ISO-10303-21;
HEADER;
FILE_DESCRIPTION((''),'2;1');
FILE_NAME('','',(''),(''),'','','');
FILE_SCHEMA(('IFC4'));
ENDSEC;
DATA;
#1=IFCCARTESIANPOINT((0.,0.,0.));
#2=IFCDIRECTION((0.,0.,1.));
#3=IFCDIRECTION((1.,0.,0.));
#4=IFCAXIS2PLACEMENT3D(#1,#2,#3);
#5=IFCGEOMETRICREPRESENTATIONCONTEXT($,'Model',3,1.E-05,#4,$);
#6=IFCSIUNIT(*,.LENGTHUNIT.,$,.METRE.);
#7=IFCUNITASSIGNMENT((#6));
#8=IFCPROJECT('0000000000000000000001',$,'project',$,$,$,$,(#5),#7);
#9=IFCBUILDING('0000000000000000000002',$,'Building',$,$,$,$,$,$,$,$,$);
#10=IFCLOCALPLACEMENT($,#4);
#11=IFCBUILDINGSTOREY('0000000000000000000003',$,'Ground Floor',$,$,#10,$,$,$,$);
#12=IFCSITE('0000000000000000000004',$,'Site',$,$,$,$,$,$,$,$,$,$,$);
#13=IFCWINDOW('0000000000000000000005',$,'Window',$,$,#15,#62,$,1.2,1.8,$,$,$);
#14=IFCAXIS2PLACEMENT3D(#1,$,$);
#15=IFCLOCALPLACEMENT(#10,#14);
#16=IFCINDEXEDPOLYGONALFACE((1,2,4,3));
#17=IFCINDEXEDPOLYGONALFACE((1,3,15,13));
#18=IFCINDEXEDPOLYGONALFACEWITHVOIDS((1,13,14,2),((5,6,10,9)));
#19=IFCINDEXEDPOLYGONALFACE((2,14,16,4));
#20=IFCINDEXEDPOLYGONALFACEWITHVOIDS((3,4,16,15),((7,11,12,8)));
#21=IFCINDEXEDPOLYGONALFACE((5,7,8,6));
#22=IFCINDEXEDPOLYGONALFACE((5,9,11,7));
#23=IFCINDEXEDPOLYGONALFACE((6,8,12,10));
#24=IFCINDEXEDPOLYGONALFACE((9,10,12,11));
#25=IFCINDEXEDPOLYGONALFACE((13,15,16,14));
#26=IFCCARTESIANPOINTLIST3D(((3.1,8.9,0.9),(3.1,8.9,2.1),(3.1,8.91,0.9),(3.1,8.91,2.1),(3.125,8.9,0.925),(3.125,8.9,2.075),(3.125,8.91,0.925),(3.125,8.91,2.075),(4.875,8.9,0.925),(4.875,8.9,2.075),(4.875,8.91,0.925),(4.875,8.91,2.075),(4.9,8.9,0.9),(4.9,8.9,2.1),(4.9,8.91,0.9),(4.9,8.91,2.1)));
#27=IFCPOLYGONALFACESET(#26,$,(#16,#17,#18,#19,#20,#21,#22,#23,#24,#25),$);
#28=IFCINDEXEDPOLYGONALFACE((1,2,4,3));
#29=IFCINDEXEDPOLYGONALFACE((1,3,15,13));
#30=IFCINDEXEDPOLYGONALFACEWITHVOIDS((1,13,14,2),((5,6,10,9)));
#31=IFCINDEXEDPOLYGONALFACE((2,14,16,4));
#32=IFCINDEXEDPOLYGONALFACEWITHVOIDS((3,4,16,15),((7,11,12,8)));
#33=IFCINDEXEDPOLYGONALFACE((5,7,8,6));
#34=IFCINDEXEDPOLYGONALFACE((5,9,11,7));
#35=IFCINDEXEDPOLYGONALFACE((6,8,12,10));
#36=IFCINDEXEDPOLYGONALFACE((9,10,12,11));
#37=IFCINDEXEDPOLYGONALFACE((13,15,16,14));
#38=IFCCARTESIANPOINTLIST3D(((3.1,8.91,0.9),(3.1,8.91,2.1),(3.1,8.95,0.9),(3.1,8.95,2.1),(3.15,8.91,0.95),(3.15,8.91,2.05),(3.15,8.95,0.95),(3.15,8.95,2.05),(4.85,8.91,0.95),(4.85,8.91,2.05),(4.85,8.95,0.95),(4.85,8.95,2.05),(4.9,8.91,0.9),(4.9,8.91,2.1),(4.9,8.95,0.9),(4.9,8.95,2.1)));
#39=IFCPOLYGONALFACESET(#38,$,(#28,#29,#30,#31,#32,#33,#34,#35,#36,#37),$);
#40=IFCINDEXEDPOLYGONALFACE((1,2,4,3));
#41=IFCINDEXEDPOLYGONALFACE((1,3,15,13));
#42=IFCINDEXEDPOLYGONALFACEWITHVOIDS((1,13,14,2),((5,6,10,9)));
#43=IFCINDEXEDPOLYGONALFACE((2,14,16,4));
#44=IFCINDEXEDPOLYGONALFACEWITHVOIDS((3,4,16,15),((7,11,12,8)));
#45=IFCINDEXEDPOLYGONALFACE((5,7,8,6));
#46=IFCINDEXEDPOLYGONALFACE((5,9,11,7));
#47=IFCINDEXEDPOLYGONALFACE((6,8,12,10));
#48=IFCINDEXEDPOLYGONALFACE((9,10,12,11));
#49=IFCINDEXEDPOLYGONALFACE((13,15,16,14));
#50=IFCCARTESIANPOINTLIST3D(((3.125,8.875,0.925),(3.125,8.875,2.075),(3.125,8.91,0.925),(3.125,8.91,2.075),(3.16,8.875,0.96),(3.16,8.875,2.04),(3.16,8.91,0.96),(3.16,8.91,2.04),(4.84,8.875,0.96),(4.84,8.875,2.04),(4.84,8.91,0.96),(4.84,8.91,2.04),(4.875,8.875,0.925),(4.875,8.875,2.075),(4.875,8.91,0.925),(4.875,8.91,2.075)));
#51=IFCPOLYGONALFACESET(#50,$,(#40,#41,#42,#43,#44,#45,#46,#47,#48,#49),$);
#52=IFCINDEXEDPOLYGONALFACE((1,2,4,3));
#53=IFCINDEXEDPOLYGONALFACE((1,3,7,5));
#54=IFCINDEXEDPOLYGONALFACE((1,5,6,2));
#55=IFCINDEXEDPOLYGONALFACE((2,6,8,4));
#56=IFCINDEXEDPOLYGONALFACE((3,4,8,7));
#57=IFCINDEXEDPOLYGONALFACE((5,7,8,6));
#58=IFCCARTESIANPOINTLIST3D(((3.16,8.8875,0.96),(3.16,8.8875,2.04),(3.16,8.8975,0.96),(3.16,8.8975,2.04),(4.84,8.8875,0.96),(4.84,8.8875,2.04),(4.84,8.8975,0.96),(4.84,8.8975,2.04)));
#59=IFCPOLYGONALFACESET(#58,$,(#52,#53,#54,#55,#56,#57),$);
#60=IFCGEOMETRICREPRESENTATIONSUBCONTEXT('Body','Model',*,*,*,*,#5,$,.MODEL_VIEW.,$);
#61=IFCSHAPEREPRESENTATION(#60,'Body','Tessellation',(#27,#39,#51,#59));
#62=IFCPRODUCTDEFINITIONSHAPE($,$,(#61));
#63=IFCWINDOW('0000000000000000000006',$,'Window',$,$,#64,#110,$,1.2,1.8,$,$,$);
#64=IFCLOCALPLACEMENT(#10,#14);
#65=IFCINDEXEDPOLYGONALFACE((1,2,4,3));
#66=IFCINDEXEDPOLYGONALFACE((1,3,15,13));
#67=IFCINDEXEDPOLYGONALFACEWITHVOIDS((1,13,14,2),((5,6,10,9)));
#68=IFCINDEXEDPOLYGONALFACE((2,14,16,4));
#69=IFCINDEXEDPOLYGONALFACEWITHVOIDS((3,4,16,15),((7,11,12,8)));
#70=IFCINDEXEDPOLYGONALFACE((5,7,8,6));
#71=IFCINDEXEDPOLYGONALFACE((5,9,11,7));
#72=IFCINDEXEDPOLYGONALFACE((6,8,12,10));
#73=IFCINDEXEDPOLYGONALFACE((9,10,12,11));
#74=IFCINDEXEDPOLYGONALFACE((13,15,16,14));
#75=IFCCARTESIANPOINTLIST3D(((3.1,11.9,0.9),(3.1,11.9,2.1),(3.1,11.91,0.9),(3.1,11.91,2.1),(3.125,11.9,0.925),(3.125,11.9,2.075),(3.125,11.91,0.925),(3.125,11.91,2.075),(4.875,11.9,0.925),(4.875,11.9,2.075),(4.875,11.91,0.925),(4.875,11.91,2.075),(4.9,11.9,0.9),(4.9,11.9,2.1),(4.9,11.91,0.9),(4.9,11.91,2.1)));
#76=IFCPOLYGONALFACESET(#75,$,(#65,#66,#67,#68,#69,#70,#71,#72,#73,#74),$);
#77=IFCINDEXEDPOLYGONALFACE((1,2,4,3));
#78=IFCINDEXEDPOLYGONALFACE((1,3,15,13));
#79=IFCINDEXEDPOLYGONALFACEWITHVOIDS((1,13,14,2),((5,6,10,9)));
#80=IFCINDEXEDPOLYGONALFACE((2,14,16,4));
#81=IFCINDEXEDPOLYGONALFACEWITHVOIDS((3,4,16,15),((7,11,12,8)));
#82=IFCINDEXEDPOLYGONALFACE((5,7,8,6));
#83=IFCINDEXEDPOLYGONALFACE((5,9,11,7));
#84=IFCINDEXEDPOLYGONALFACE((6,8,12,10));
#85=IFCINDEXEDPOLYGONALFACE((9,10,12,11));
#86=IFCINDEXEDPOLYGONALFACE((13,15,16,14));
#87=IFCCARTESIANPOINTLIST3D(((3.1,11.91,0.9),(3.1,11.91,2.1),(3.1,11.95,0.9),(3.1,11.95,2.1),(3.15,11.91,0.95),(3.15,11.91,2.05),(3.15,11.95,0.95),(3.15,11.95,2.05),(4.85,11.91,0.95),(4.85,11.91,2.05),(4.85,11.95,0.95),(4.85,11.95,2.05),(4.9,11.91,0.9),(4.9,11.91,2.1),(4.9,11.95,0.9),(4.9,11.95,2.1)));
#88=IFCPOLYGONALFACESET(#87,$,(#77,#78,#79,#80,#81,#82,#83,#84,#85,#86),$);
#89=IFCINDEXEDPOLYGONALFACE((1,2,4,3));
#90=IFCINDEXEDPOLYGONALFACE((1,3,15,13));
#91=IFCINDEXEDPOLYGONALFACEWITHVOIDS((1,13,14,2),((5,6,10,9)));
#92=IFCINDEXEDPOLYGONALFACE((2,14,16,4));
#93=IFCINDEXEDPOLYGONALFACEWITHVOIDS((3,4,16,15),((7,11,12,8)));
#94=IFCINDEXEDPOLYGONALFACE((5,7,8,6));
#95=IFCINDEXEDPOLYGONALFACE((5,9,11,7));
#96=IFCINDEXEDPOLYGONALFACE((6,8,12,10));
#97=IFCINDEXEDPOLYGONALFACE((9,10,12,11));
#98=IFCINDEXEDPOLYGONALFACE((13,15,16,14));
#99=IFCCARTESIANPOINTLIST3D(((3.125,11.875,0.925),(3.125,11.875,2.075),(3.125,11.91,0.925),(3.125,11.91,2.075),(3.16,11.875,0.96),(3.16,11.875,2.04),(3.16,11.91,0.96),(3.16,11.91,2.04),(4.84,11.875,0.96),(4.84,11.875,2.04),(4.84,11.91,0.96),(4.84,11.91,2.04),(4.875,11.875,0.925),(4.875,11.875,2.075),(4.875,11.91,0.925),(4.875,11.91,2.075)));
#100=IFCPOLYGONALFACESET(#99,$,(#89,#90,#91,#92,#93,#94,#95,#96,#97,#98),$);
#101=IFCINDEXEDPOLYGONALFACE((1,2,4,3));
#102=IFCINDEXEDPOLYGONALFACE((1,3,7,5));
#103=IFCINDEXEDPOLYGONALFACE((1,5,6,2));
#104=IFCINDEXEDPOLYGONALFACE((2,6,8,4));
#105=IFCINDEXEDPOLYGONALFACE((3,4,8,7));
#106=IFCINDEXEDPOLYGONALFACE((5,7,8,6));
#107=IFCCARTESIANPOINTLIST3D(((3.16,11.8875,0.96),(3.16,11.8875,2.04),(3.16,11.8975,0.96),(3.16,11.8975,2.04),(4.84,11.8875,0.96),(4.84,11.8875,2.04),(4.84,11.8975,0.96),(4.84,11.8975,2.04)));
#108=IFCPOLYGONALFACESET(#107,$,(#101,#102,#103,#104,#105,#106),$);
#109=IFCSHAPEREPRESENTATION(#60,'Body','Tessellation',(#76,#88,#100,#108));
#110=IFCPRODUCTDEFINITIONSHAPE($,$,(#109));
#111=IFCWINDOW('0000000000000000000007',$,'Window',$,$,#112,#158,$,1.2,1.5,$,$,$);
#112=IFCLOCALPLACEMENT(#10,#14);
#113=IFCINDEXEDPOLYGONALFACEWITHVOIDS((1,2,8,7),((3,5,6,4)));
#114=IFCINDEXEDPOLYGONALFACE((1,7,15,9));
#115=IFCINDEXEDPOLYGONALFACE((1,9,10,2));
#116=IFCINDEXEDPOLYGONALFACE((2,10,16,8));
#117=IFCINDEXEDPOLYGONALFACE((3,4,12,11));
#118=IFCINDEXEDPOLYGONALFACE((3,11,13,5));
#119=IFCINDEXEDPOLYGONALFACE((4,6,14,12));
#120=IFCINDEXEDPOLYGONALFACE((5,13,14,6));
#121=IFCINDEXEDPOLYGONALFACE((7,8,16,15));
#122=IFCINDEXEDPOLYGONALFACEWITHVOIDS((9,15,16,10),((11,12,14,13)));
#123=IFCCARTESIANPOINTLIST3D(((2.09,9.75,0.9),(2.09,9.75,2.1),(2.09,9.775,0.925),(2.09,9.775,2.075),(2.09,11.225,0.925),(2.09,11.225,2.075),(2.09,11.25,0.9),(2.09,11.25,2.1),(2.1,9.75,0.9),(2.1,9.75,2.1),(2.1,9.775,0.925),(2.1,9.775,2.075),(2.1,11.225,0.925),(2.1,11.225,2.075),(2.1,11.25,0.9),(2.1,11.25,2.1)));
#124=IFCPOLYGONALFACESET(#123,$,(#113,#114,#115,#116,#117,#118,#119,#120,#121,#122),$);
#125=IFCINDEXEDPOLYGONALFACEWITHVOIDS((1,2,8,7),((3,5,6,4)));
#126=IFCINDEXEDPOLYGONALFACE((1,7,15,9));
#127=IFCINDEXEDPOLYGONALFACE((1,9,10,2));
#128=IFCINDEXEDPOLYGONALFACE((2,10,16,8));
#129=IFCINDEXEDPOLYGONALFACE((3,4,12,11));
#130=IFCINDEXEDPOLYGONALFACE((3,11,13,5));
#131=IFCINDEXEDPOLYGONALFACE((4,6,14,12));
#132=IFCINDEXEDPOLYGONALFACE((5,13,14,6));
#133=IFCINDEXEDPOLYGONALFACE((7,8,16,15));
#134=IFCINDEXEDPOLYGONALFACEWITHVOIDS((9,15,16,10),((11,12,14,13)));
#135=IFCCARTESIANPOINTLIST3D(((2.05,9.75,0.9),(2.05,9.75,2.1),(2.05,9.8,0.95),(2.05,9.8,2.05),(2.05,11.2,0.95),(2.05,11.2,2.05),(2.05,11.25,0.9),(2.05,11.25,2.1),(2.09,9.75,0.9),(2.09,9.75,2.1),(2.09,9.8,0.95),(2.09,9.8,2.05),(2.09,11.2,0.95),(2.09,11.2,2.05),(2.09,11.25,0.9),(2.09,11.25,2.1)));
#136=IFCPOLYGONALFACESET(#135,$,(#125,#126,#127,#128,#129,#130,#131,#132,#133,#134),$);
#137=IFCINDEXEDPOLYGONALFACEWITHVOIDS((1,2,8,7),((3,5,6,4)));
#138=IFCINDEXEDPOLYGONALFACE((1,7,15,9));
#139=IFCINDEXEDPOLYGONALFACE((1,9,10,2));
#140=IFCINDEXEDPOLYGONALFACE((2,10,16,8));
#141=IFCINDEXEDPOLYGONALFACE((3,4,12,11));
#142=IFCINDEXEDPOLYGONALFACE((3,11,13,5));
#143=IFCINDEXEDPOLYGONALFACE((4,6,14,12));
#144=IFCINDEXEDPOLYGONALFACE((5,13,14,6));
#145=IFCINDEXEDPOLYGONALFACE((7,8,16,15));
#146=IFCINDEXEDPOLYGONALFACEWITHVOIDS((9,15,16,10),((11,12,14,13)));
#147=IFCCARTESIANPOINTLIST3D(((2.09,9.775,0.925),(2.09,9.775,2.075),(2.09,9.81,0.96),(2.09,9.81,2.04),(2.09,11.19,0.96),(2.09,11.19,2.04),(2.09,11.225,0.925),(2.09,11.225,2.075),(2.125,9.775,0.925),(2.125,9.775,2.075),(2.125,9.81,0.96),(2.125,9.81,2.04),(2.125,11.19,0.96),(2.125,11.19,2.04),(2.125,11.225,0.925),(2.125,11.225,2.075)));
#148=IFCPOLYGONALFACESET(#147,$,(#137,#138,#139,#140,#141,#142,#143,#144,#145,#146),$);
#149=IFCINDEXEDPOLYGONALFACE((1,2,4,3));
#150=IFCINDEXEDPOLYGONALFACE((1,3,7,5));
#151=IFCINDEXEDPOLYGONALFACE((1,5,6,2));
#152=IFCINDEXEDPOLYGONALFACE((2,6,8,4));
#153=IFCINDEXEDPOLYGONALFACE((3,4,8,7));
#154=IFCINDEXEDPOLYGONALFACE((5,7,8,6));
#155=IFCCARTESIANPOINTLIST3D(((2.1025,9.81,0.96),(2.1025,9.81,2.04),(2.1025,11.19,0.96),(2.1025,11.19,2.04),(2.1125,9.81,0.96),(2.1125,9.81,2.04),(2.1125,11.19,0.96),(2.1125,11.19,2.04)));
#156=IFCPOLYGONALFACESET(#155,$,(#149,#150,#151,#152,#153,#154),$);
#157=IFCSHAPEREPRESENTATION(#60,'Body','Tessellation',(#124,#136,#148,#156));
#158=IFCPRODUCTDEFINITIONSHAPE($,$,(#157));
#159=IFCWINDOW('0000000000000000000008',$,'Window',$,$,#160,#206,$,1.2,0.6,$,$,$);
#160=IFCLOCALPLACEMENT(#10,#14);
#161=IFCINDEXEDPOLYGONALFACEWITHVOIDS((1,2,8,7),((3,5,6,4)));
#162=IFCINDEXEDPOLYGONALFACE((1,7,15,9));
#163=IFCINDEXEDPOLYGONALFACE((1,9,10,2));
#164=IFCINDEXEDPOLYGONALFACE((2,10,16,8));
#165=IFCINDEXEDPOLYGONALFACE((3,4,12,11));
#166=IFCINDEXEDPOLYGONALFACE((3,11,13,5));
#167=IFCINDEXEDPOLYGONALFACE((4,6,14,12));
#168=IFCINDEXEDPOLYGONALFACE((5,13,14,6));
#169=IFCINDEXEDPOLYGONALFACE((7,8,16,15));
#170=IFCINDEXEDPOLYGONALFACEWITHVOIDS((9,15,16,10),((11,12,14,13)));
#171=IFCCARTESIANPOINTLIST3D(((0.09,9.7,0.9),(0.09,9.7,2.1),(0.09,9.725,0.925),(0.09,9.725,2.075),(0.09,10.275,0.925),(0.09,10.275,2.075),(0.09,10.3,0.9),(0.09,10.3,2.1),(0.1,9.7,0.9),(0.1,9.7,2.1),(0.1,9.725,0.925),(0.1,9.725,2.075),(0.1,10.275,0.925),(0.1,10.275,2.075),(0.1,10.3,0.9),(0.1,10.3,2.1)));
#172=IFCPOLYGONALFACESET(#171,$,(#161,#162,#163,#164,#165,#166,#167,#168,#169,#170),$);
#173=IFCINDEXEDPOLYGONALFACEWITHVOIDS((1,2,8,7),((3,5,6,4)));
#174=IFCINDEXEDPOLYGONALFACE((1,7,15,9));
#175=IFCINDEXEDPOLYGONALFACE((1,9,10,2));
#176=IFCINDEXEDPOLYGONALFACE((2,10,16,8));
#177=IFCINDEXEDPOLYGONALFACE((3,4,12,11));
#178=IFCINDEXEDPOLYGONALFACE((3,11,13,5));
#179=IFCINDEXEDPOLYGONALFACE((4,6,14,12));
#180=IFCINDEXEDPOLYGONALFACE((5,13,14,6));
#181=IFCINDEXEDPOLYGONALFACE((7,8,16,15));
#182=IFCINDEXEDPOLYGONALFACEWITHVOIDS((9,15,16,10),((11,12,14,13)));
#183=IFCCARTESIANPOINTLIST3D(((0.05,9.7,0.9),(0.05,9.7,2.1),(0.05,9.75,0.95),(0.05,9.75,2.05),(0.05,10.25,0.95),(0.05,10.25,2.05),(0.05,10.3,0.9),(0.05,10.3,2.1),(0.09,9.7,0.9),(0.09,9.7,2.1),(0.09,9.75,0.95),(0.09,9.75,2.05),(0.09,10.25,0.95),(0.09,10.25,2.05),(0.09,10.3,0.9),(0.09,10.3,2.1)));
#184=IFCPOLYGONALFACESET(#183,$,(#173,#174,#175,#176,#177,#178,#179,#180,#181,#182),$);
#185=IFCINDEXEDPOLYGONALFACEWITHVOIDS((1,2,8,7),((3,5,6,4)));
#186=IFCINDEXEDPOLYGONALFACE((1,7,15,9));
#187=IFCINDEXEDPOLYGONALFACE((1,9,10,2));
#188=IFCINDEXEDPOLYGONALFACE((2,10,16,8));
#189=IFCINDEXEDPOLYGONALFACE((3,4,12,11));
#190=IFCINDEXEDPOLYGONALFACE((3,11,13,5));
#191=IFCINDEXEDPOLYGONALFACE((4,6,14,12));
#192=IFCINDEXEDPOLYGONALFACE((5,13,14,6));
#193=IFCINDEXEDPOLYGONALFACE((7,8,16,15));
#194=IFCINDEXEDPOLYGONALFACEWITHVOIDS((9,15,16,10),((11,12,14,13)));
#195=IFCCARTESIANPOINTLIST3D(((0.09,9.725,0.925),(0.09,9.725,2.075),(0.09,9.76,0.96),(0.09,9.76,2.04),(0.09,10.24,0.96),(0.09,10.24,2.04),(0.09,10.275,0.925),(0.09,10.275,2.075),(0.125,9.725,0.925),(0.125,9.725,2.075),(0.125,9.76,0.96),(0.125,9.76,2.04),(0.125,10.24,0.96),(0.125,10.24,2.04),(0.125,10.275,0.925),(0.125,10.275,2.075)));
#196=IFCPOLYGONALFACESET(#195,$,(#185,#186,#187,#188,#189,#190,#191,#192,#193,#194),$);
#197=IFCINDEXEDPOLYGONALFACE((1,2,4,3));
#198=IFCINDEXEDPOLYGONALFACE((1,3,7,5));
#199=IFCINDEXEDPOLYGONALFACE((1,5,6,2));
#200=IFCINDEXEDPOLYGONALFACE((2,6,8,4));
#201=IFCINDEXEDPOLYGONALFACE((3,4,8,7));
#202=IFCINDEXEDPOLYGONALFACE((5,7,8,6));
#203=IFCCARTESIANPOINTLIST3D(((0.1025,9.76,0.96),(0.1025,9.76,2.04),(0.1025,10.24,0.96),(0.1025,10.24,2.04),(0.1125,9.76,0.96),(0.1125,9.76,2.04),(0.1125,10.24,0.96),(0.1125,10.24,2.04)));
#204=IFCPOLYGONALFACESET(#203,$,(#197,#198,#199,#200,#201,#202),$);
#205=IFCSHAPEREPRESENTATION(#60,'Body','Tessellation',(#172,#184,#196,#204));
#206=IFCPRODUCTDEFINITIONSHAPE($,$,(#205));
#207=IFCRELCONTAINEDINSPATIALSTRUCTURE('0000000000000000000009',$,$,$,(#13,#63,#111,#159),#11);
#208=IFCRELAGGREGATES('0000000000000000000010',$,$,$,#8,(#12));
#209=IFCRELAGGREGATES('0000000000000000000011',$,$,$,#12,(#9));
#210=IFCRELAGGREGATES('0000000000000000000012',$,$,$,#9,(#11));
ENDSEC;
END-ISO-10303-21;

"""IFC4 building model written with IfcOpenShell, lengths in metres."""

from ifc_helpers import new_model, si_unit, frame, origin_with_axes, place, context, subcontext, project, spatial, line, indexed_curve, outline, extrude, element, save


model = new_model("IFC4")

# Units and contexts
model_context = context("Model", 3, precision=1e-05, world=origin_with_axes())
body_context = subcontext(model_context, "Body", "Model", "MODEL_VIEW")
ifc_project = project(units=[si_unit("LENGTHUNIT", "METRE")], contexts=[model_context])

# Site, building, storey
site = spatial("IfcSite", under=ifc_project, Name="Site")
building = spatial("IfcBuilding", under=site, Name="Building")
storey_placement = place(None, origin_with_axes())
storey = spatial("IfcBuildingStorey", under=building, at=storey_placement, Name="Ground Floor")

# Windows
for number, where, z_axis, x_axis, name in (
    (1, (4.9, 9.0, 0.9), (0.0, 0.0, 1.0), (-1.0, 0.0, 0.0), "Window"),
    (2, (4.9, 12.0, 0.9), (0.0, 0.0, 1.0), (-1.0, 0.0, 0.0), "Window"),
):
    element("IfcWindow", number, at=place(storey_placement, frame(where, z_axis=z_axis, x_axis=x_axis)), inside=storey, Name=name, OverallHeight=1.2, OverallWidth=1.8, context=body_context, shape_type="SweptSolid", body=[
        extrude(outline(indexed_curve([(0.0, 0.0), (1.8, 0.0), (1.8, 1.2), (0.0, 1.2)], segments=[line(1, 2, 3, 4, 1)]), holes=[indexed_curve([(0.025, 0.025), (1.775, 0.025), (1.775, 1.175), (0.025, 1.175)], segments=[line(1, 2, 3, 4, 1)])]), frame((0.0, 0.09, 0.0), z_axis=(0.0, -1.0, 0.0), x_axis=(1.0, 0.0, 0.0)), (0.0, 0.0, -1.0), 0.01),
        extrude(outline(indexed_curve([(0.0, 0.0), (1.8, 0.0), (1.8, 1.2), (0.0, 1.2)], segments=[line(1, 2, 3, 4, 1)]), holes=[indexed_curve([(0.05, 0.05), (1.75, 0.05), (1.75, 1.15), (0.05, 1.15)], segments=[line(1, 2, 3, 4, 1)])]), frame((0.0, 0.05, 0.0), z_axis=(0.0, -1.0, 0.0), x_axis=(1.0, 0.0, 0.0)), (0.0, 0.0, -1.0), 0.04),
        extrude(outline(indexed_curve([(0.0, 0.0), (1.75, 0.0), (1.75, 1.15), (0.0, 1.15)], segments=[line(1, 2, 3, 4, 1)]), holes=[indexed_curve([(0.035, 0.035), (1.715, 0.035), (1.715, 1.115), (0.035, 1.115)], segments=[line(1, 2, 3, 4, 1)])]), frame((0.025, 0.09, 0.025), z_axis=(0.0, -1.0, 0.0), x_axis=(1.0, 0.0, 0.0)), (0.0, 0.0, -1.0), 0.035),
        extrude(outline(indexed_curve([(0.035, 0.035), (1.715, 0.035), (1.715, 1.115), (0.035, 1.115)], segments=[line(1, 2, 3, 4, 1)])), frame((0.025, 0.1025, 0.025), z_axis=(0.0, -1.0, 0.0), x_axis=(1.0, 0.0, 0.0)), (0.0, 0.0, -1.0), 0.01),
    ])
window_1_placement = place(storey_placement, frame((2.0, 11.25, 0.9), z_axis=(0.0, 0.0, 1.0), x_axis=(0.0, -1.0, 0.0)))
element("IfcWindow", 3, at=window_1_placement, inside=storey, Name="Window", OverallHeight=1.2, OverallWidth=1.5, context=body_context, shape_type="SweptSolid", body=[
    extrude(outline(indexed_curve([(0.0, 0.0), (1.5, 0.0), (1.5, 1.2), (0.0, 1.2)], segments=[line(1, 2, 3, 4, 1)]), holes=[indexed_curve([(0.025, 0.025), (1.475, 0.025), (1.475, 1.175), (0.025, 1.175)], segments=[line(1, 2, 3, 4, 1)])]), frame((0.0, 0.09, 0.0), z_axis=(0.0, -1.0, 0.0), x_axis=(1.0, 0.0, 0.0)), (0.0, 0.0, -1.0), 0.01),
    extrude(outline(indexed_curve([(0.0, 0.0), (1.5, 0.0), (1.5, 1.2), (0.0, 1.2)], segments=[line(1, 2, 3, 4, 1)]), holes=[indexed_curve([(0.05, 0.05), (1.45, 0.05), (1.45, 1.15), (0.05, 1.15)], segments=[line(1, 2, 3, 4, 1)])]), frame((0.0, 0.05, 0.0), z_axis=(0.0, -1.0, 0.0), x_axis=(1.0, 0.0, 0.0)), (0.0, 0.0, -1.0), 0.04),
    extrude(outline(indexed_curve([(0.0, 0.0), (1.45, 0.0), (1.45, 1.15), (0.0, 1.15)], segments=[line(1, 2, 3, 4, 1)]), holes=[indexed_curve([(0.035, 0.035), (1.415, 0.035), (1.415, 1.115), (0.035, 1.115)], segments=[line(1, 2, 3, 4, 1)])]), frame((0.025, 0.09, 0.025), z_axis=(0.0, -1.0, 0.0), x_axis=(1.0, 0.0, 0.0)), (0.0, 0.0, -1.0), 0.035),
    extrude(outline(indexed_curve([(0.035, 0.035), (1.415, 0.035), (1.415, 1.115), (0.035, 1.115)], segments=[line(1, 2, 3, 4, 1)])), frame((0.025, 0.1025, 0.025), z_axis=(0.0, -1.0, 0.0), x_axis=(1.0, 0.0, 0.0)), (0.0, 0.0, -1.0), 0.01),
])
window_2_placement = place(storey_placement, frame((0.0, 10.3, 0.9), z_axis=(0.0, 0.0, 1.0), x_axis=(0.0, -1.0, 0.0)))
element("IfcWindow", 4, at=window_2_placement, inside=storey, Name="Window", OverallHeight=1.2, OverallWidth=0.6, context=body_context, shape_type="SweptSolid", body=[
    extrude(outline(indexed_curve([(0.0, 0.0), (0.6, 0.0), (0.6, 1.2), (0.0, 1.2)], segments=[line(1, 2, 3, 4, 1)]), holes=[indexed_curve([(0.025, 0.025), (0.575, 0.025), (0.575, 1.175), (0.025, 1.175)], segments=[line(1, 2, 3, 4, 1)])]), frame((0.0, 0.09, 0.0), z_axis=(0.0, -1.0, 0.0), x_axis=(1.0, 0.0, 0.0)), (0.0, 0.0, -1.0), 0.01),
    extrude(outline(indexed_curve([(0.0, 0.0), (0.6, 0.0), (0.6, 1.2), (0.0, 1.2)], segments=[line(1, 2, 3, 4, 1)]), holes=[indexed_curve([(0.05, 0.05), (0.55, 0.05), (0.55, 1.15), (0.05, 1.15)], segments=[line(1, 2, 3, 4, 1)])]), frame((0.0, 0.05, 0.0), z_axis=(0.0, -1.0, 0.0), x_axis=(1.0, 0.0, 0.0)), (0.0, 0.0, -1.0), 0.04),
    extrude(outline(indexed_curve([(0.0, 0.0), (0.55, 0.0), (0.55, 1.15), (0.0, 1.15)], segments=[line(1, 2, 3, 4, 1)]), holes=[indexed_curve([(0.035, 0.035), (0.515, 0.035), (0.515, 1.115), (0.035, 1.115)], segments=[line(1, 2, 3, 4, 1)])]), frame((0.025, 0.09, 0.025), z_axis=(0.0, -1.0, 0.0), x_axis=(1.0, 0.0, 0.0)), (0.0, 0.0, -1.0), 0.035),
    extrude(outline(indexed_curve([(0.035, 0.035), (0.515, 0.035), (0.515, 1.115), (0.035, 1.115)], segments=[line(1, 2, 3, 4, 1)])), frame((0.025, 0.1025, 0.025), z_axis=(0.0, -1.0, 0.0), x_axis=(1.0, 0.0, 0.0)), (0.0, 0.0, -1.0), 0.01),
])

save(model, "model.ifc")
